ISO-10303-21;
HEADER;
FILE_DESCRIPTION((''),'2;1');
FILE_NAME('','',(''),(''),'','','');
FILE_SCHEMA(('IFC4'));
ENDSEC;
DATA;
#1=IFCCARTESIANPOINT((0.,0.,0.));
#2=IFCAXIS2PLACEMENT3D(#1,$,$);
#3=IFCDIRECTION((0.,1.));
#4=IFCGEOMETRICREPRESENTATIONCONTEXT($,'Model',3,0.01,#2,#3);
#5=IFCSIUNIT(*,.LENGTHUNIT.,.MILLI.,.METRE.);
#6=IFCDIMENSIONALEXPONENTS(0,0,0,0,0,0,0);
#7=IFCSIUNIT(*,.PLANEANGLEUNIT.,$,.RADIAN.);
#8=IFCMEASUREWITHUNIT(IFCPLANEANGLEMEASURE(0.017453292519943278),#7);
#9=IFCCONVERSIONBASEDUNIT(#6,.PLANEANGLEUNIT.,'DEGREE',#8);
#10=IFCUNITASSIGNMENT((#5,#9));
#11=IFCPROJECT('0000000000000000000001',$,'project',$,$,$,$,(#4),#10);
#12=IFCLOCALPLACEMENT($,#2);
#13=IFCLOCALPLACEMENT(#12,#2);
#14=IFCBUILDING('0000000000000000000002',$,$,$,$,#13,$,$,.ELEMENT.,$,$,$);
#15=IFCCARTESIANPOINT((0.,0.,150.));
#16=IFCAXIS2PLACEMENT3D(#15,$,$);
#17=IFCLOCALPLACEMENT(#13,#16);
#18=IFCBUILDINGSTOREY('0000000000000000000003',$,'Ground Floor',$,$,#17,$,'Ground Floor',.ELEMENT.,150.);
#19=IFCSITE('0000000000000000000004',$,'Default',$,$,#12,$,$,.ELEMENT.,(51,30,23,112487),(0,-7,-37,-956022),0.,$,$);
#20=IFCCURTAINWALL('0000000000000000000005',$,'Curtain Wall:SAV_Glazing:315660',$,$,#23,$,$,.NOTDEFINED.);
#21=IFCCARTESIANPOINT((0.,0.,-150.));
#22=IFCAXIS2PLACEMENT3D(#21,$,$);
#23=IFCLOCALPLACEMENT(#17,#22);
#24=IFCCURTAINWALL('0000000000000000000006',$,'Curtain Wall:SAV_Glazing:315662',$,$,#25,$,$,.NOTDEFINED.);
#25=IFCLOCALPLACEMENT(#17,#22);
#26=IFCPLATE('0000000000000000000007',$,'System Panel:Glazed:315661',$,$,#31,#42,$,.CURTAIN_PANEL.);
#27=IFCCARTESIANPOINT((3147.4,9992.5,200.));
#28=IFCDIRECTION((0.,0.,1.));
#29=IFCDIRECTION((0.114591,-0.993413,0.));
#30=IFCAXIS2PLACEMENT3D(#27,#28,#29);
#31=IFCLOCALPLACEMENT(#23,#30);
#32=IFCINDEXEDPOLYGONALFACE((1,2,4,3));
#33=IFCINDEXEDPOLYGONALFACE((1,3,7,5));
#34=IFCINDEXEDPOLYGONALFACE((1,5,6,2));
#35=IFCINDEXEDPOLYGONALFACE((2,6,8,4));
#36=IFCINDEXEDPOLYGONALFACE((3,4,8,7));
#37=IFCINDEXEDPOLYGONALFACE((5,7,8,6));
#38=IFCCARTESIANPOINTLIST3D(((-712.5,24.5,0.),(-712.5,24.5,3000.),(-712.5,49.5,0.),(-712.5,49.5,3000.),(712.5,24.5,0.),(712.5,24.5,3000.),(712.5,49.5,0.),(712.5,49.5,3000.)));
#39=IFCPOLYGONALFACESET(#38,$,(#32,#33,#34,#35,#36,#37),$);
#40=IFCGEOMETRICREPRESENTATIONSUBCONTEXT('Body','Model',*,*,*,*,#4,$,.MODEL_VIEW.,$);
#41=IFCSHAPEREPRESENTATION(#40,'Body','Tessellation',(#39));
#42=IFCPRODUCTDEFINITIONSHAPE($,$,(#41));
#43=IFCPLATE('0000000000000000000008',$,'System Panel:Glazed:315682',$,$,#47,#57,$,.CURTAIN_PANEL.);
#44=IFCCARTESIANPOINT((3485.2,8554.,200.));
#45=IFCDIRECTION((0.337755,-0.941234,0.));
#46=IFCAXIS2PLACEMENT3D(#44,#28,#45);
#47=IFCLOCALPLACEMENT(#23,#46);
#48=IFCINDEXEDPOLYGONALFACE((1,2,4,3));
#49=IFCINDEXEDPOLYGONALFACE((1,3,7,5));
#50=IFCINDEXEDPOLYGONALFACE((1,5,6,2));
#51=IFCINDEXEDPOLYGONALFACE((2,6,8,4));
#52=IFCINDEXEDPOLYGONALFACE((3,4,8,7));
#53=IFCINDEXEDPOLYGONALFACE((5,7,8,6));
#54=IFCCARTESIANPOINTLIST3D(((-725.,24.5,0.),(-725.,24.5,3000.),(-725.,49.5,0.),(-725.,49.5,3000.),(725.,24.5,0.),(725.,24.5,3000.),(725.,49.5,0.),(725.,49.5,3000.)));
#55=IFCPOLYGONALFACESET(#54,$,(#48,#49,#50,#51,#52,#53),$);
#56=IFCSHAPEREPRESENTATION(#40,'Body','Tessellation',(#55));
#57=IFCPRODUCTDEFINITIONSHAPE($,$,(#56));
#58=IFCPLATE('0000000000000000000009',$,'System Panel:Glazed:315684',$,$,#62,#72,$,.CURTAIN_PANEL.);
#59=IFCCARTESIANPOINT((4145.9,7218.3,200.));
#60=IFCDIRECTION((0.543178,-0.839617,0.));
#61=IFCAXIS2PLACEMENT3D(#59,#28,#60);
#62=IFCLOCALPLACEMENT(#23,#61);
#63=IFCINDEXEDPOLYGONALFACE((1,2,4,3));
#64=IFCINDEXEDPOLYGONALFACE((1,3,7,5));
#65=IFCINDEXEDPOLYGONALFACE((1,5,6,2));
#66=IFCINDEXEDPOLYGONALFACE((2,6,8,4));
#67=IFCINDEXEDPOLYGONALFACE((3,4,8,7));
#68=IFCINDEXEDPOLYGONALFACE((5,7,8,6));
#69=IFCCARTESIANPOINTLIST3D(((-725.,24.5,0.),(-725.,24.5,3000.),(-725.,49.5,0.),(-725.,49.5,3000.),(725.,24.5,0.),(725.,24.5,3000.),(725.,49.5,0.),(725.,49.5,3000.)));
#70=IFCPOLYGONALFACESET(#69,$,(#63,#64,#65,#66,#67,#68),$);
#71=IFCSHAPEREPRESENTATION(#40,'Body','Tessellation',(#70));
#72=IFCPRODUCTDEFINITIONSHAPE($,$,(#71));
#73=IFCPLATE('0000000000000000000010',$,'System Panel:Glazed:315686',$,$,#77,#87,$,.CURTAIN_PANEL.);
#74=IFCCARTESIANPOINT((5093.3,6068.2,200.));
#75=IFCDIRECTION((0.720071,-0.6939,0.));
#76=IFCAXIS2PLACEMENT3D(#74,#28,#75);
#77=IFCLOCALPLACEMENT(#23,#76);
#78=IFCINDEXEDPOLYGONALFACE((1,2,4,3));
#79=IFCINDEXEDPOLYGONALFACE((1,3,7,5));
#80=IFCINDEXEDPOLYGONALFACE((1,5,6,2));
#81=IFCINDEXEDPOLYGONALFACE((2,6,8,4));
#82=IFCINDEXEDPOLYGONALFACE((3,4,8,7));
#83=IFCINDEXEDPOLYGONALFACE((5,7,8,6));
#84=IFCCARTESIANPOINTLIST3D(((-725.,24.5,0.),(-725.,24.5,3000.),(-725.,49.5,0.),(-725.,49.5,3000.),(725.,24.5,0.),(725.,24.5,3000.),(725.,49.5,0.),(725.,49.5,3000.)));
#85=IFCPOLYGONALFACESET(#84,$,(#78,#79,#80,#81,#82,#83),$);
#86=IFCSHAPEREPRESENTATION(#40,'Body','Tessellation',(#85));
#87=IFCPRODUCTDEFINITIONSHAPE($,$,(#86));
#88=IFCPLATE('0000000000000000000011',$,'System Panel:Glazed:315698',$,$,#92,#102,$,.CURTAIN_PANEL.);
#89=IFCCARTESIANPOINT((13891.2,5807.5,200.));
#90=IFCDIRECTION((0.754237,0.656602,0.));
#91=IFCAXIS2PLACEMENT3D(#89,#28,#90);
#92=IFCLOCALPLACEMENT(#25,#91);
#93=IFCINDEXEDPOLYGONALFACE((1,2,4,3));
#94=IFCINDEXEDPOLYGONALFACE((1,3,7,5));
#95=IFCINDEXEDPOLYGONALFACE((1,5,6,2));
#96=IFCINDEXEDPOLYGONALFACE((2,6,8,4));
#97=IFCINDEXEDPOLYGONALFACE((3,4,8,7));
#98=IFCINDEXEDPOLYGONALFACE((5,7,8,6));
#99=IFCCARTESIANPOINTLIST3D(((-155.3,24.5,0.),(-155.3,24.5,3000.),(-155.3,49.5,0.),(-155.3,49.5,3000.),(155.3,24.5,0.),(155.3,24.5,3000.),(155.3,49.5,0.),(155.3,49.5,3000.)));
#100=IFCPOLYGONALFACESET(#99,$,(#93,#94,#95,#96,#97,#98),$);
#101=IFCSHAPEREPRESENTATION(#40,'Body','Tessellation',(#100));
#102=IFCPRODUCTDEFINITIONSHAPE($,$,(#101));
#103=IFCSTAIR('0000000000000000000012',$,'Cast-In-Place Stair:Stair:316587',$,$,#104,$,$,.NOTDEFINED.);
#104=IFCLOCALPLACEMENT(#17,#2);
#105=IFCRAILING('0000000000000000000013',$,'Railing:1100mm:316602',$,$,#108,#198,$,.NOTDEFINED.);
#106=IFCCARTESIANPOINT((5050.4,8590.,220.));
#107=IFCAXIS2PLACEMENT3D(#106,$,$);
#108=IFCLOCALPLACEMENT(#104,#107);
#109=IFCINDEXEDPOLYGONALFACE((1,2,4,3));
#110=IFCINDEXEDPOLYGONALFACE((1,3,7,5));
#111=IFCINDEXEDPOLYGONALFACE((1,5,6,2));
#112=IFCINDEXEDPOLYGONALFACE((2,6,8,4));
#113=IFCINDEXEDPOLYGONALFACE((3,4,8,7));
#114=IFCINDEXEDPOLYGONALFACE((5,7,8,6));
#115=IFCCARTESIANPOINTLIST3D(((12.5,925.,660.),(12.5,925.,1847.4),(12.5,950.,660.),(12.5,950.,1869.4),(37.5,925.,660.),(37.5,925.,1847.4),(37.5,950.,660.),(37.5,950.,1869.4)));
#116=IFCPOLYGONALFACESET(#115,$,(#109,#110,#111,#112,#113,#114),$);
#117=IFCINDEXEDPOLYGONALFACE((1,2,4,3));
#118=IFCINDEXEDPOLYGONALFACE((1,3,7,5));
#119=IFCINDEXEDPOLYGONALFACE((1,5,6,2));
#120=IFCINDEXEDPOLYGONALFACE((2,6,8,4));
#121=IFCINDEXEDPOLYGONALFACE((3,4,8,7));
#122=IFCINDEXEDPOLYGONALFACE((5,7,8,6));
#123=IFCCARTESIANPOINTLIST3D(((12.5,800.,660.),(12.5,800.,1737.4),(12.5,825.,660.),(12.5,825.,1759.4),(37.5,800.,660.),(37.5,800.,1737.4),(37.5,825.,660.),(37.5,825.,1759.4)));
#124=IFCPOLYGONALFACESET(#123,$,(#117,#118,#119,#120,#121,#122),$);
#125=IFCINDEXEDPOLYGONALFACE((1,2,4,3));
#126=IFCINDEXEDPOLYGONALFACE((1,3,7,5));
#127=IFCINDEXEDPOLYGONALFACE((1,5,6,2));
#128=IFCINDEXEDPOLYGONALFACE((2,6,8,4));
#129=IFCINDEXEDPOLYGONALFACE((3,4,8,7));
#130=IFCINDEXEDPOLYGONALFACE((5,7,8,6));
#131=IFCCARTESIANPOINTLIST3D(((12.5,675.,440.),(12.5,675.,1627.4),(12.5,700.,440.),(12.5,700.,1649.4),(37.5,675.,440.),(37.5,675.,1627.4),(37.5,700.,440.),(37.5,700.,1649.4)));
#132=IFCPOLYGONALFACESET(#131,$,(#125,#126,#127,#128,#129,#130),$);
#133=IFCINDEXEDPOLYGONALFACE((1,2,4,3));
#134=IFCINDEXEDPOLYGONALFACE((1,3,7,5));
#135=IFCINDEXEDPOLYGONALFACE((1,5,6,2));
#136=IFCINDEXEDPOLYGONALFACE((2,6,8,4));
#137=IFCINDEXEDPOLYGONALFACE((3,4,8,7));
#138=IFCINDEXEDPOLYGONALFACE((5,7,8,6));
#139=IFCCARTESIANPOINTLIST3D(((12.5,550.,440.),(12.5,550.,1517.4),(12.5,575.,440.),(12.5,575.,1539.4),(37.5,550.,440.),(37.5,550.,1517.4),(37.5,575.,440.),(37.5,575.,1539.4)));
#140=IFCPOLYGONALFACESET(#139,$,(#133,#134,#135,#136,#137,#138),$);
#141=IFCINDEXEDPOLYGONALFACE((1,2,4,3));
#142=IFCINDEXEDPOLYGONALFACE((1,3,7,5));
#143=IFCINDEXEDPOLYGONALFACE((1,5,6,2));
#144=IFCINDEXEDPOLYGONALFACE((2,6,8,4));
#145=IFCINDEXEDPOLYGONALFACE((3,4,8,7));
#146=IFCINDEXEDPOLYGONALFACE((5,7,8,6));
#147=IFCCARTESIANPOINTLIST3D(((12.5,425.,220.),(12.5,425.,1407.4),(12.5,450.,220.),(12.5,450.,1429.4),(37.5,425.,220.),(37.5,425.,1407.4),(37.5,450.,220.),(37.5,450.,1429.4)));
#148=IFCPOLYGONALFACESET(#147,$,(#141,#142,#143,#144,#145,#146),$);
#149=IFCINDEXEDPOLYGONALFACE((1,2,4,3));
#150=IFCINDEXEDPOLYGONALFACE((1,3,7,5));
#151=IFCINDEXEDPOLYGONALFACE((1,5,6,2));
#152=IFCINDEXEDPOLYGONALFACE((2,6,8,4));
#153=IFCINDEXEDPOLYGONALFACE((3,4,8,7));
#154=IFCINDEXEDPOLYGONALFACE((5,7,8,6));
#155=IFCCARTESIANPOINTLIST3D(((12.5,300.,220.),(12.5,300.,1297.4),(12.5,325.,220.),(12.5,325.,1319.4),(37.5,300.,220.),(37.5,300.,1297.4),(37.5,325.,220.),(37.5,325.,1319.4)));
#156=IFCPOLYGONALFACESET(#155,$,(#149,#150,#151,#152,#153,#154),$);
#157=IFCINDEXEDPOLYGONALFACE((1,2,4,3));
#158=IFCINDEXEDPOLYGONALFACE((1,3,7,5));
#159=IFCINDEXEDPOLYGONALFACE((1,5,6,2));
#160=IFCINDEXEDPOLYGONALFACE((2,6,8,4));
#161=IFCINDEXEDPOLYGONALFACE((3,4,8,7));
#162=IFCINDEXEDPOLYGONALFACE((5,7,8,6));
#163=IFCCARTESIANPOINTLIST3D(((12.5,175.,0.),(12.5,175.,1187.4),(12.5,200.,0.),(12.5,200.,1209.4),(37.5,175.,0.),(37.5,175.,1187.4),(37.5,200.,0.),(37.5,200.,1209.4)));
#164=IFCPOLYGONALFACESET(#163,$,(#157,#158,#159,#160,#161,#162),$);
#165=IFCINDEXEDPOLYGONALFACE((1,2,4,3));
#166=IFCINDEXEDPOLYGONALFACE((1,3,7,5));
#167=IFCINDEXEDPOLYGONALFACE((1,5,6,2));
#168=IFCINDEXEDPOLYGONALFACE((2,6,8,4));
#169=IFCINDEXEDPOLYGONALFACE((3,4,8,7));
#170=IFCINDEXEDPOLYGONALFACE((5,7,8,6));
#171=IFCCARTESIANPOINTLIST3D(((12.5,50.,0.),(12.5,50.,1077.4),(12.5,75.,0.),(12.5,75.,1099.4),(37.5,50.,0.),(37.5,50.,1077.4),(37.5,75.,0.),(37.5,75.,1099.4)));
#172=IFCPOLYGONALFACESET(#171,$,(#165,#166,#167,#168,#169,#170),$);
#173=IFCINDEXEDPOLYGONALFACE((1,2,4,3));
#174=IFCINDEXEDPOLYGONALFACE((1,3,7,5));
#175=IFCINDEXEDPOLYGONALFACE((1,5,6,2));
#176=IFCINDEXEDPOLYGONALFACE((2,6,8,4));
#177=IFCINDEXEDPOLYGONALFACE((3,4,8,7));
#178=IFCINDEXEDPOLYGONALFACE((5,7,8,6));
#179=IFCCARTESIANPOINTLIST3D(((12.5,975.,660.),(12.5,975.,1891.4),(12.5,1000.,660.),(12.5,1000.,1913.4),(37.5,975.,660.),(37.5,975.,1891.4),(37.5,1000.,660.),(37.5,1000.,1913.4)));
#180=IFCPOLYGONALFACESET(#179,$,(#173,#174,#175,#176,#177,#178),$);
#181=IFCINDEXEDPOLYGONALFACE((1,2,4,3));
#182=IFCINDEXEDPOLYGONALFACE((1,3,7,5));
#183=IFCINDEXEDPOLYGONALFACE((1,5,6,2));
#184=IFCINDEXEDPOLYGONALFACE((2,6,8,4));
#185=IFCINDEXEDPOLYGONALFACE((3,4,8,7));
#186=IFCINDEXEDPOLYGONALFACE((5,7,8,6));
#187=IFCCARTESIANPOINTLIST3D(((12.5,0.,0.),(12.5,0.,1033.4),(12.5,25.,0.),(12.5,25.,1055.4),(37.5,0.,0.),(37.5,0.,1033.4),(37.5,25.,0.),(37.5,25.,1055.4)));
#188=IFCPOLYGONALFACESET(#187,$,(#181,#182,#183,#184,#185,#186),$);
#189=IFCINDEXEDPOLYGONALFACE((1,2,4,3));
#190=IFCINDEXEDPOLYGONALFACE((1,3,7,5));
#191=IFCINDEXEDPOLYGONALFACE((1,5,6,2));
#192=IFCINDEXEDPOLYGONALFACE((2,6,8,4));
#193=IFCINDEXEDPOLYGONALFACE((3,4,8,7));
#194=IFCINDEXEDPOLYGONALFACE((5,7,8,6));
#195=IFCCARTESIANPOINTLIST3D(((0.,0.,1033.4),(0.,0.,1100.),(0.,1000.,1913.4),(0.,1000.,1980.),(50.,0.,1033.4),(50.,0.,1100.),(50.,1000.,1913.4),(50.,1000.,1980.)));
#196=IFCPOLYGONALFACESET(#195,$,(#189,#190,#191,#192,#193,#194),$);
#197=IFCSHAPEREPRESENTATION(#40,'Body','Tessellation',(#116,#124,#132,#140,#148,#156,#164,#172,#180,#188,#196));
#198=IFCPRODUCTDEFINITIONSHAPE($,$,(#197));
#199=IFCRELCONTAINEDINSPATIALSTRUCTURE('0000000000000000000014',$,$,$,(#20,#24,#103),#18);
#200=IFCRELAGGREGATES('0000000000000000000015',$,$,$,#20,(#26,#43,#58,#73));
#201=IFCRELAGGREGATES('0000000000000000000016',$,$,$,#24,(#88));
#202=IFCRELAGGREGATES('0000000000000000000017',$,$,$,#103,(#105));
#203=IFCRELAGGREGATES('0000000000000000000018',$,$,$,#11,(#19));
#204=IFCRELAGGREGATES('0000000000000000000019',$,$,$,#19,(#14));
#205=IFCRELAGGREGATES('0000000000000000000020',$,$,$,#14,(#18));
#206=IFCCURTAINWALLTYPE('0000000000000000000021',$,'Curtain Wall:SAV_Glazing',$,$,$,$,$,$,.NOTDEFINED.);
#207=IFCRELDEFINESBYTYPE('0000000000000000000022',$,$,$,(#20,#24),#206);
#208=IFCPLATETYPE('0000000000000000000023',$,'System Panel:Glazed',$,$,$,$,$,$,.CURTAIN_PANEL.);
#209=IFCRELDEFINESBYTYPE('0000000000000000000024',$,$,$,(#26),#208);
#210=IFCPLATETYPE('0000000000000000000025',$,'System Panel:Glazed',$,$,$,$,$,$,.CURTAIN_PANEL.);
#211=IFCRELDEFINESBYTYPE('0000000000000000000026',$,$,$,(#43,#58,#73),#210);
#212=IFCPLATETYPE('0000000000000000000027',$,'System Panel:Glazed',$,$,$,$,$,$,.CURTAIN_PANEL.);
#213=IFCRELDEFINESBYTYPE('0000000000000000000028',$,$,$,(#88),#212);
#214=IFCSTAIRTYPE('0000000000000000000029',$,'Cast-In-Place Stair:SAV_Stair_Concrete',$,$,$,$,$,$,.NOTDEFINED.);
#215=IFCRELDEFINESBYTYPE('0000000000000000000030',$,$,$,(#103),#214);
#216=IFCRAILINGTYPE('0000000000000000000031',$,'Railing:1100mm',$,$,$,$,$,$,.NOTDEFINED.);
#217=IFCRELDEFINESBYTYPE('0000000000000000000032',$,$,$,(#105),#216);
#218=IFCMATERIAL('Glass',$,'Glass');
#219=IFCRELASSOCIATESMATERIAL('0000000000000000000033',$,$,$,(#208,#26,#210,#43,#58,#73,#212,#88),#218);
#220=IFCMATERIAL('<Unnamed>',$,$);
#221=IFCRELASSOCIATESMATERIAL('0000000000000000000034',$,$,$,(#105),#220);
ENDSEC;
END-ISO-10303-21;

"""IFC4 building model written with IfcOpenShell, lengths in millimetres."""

from ifc_helpers import new_model, entity, si_unit, converted_unit, direction, frame, frame_2d, origin, place, context, subcontext, project, spatial, polyline, rectangle, outline, extrude, source, transform, mapped, material, type_object, type_shapes, element, aggregate, save


model = new_model("IFC4")

# Units and contexts
model_context = context("Model", 3, precision=0.01, world=origin(), true_north=direction((0.0, 1.0)))
body_context = subcontext(model_context, "Body", "Model", "MODEL_VIEW")
ifc_project = project(units=[si_unit("LENGTHUNIT", "METRE", prefix="MILLI"), converted_unit("PLANEANGLEUNIT", "DEGREE", entity("IfcPlaneAngleMeasure", 0.017453292519943278), si_unit("PLANEANGLEUNIT", "RADIAN"), dimensions=[0, 0, 0, 0, 0, 0, 0])], contexts=[model_context])

# Site, building, storey
site_placement = place(None, origin())
site = spatial("IfcSite", under=ifc_project, at=site_placement, Name="Default", CompositionType="ELEMENT", RefLatitude=(51, 30, 23, 112487), RefLongitude=(0, -7, -37, -956022), RefElevation=0.0)
building_placement = place(site_placement, origin())
building = spatial("IfcBuilding", under=site, at=building_placement, CompositionType="ELEMENT")
storey_placement = place(building_placement, frame((0.0, 0.0, 150.0)))
storey = spatial("IfcBuildingStorey", under=building, at=storey_placement, Name="Ground Floor", LongName="Ground Floor", CompositionType="ELEMENT", Elevation=150.0)

# Curtain walls
curtain_wall_type = type_object("IfcCurtainWallType", Name="Curtain Wall:SAV_Glazing", PredefinedType="NOTDEFINED")
curtain_wall_1_placement = place(storey_placement, frame((0.0, 0.0, -150.0)))
curtain_wall_1 = element("IfcCurtainWall", 1, at=curtain_wall_1_placement, inside=storey, type_object=curtain_wall_type, Name="Curtain Wall:SAV_Glazing:315660", PredefinedType="NOTDEFINED")
curtain_wall_2_placement = place(storey_placement, frame((0.0, 0.0, -150.0)))
curtain_wall_2 = element("IfcCurtainWall", 2, at=curtain_wall_2_placement, inside=storey, type_object=curtain_wall_type, Name="Curtain Wall:SAV_Glazing:315662", PredefinedType="NOTDEFINED")

# Plates
ifc_material_1 = material(Name="Glass", Category="Glass")
plate_type_1 = type_object("IfcPlateType", Name="System Panel:Glazed", PredefinedType="CURTAIN_PANEL", material=ifc_material_1)
shared_shape_1 = source(origin(), body_context, "Body", "SweptSolid", [
    extrude(rectangle(XDim=25.0, YDim=1425.0, at=frame_2d((0.0, 0.0), x_axis=(1.0, 0.0))), frame((0.0, 37.0, 0.0), z_axis=(0.0, 0.0, 1.0), x_axis=(0.0, 1.0, 0.0)), (0.0, 0.0, 1.0), 3000.0),
])
type_shapes(plate_type_1, [shared_shape_1])
plate_1_placement = place(curtain_wall_1_placement, frame((3147.4, 9992.5, 200.0), z_axis=(0.0, 0.0, 1.0), x_axis=(0.114591, -0.993413, 0.0)))
plate_1 = element("IfcPlate", 3, at=plate_1_placement, type_object=plate_type_1, material=ifc_material_1, Name="System Panel:Glazed:315661", PredefinedType="CURTAIN_PANEL", context=body_context, shape_type="MappedRepresentation", body=[
    mapped(shared_shape_1, transform((0.0, 0.0, 0.0), scale=1.0)),
])
plate_type_2 = type_object("IfcPlateType", Name="System Panel:Glazed", PredefinedType="CURTAIN_PANEL", material=ifc_material_1)
shared_shape_2 = source(origin(), body_context, "Body", "SweptSolid", [
    extrude(rectangle(XDim=25.0, YDim=1450.0, at=frame_2d((0.0, 0.0), x_axis=(1.0, 0.0))), frame((0.0, 37.0, 0.0), z_axis=(0.0, 0.0, 1.0), x_axis=(0.0, 1.0, 0.0)), (0.0, 0.0, 1.0), 3000.0),
])
type_shapes(plate_type_2, [shared_shape_2])
plate_2_placement = place(curtain_wall_1_placement, frame((3485.2, 8554.0, 200.0), z_axis=(0.0, 0.0, 1.0), x_axis=(0.337755, -0.941234, 0.0)))
plate_2 = element("IfcPlate", 4, at=plate_2_placement, type_object=plate_type_2, material=ifc_material_1, Name="System Panel:Glazed:315682", PredefinedType="CURTAIN_PANEL", context=body_context, shape_type="MappedRepresentation", body=[
    mapped(shared_shape_2, transform((0.0, 0.0, 0.0), scale=1.0)),
])
plate_3_placement = place(curtain_wall_1_placement, frame((4145.9, 7218.3, 200.0), z_axis=(0.0, 0.0, 1.0), x_axis=(0.543178, -0.839617, 0.0)))
plate_3 = element("IfcPlate", 5, at=plate_3_placement, type_object=plate_type_2, material=ifc_material_1, Name="System Panel:Glazed:315684", PredefinedType="CURTAIN_PANEL", context=body_context, shape_type="MappedRepresentation", body=[
    mapped(shared_shape_2, transform((0.0, 0.0, 0.0), scale=1.0)),
])
plate_4_placement = place(curtain_wall_1_placement, frame((5093.3, 6068.2, 200.0), z_axis=(0.0, 0.0, 1.0), x_axis=(0.720071, -0.6939, 0.0)))
plate_4 = element("IfcPlate", 6, at=plate_4_placement, type_object=plate_type_2, material=ifc_material_1, Name="System Panel:Glazed:315686", PredefinedType="CURTAIN_PANEL", context=body_context, shape_type="MappedRepresentation", body=[
    mapped(shared_shape_2, transform((0.0, 0.0, 0.0), scale=1.0)),
])
aggregate(curtain_wall_1, [plate_1, plate_2, plate_3, plate_4])
plate_type_3 = type_object("IfcPlateType", Name="System Panel:Glazed", PredefinedType="CURTAIN_PANEL", material=ifc_material_1)
shared_shape_3 = source(origin(), body_context, "Body", "SweptSolid", [
    extrude(rectangle(XDim=25.0, YDim=310.6, at=frame_2d((0.0, 0.0), x_axis=(1.0, 0.0))), frame((0.0, 37.0, 0.0), z_axis=(0.0, 0.0, 1.0), x_axis=(0.0, 1.0, 0.0)), (0.0, 0.0, 1.0), 3000.0),
])
type_shapes(plate_type_3, [shared_shape_3])
plate_5_placement = place(curtain_wall_2_placement, frame((13891.2, 5807.5, 200.0), z_axis=(0.0, 0.0, 1.0), x_axis=(0.754237, 0.656602, 0.0)))
plate_5 = element("IfcPlate", 7, at=plate_5_placement, type_object=plate_type_3, material=ifc_material_1, Name="System Panel:Glazed:315698", PredefinedType="CURTAIN_PANEL", context=body_context, shape_type="MappedRepresentation", body=[
    mapped(shared_shape_3, transform((0.0, 0.0, 0.0), scale=1.0)),
])
aggregate(curtain_wall_2, [plate_5])

# Shared definitions
ifc_material_2 = material(Name="<Unnamed>")

# Stair, railing
stair_type = type_object("IfcStairType", Name="Cast-In-Place Stair:SAV_Stair_Concrete", PredefinedType="NOTDEFINED")
stair_placement = place(storey_placement, origin())
stair = element("IfcStair", 8, at=stair_placement, inside=storey, type_object=stair_type, Name="Cast-In-Place Stair:Stair:316587", PredefinedType="NOTDEFINED")
railing_type_1 = type_object("IfcRailingType", Name="Railing:1100mm", PredefinedType="NOTDEFINED")
railing_1_placement = place(stair_placement, frame((5050.4, 8590.0, 220.0)))
railing_1 = element("IfcRailing", 9, at=railing_1_placement, type_object=railing_type_1, material=ifc_material_2, Name="Railing:1100mm:316602", PredefinedType="NOTDEFINED", context=body_context, shape_type="SweptSolid", body=[
    extrude(outline(polyline([(-588.2, -12.5), (599.2, -12.5), (599.2, 12.5), (-610.2, 12.5), (-588.2, -12.5)])), frame((12.5, 937.5, 1259.2), z_axis=(1.0, 0.0, 0.0), x_axis=(0.0, 0.0, -1.0)), (0.0, 0.0, 1.0), 25.0),
    extrude(outline(polyline([(-533.2, -12.5), (544.2, -12.5), (544.2, 12.5), (-555.2, 12.5), (-533.2, -12.5)])), frame((12.5, 812.5, 1204.2), z_axis=(1.0, 0.0, 0.0), x_axis=(0.0, 0.0, -1.0)), (0.0, 0.0, 1.0), 25.0),
    extrude(outline(polyline([(-588.2, -12.5), (599.2, -12.5), (599.2, 12.5), (-610.2, 12.5), (-588.2, -12.5)])), frame((12.5, 687.5, 1039.2), z_axis=(1.0, 0.0, 0.0), x_axis=(0.0, 0.0, -1.0)), (0.0, 0.0, 1.0), 25.0),
    extrude(outline(polyline([(-533.2, -12.5), (544.2, -12.5), (544.2, 12.5), (-555.2, 12.5), (-533.2, -12.5)])), frame((12.5, 562.5, 984.2), z_axis=(1.0, 0.0, 0.0), x_axis=(0.0, 0.0, -1.0)), (0.0, 0.0, 1.0), 25.0),
    extrude(outline(polyline([(-588.2, -12.5), (599.2, -12.5), (599.2, 12.5), (-610.2, 12.5), (-588.2, -12.5)])), frame((12.5, 437.5, 819.2), z_axis=(1.0, 0.0, 0.0), x_axis=(0.0, 0.0, -1.0)), (0.0, 0.0, 1.0), 25.0),
    extrude(outline(polyline([(-533.2, -12.5), (544.2, -12.5), (544.2, 12.5), (-555.2, 12.5), (-533.2, -12.5)])), frame((12.5, 312.5, 764.2), z_axis=(1.0, 0.0, 0.0), x_axis=(0.0, 0.0, -1.0)), (0.0, 0.0, 1.0), 25.0),
    extrude(outline(polyline([(-588.2, -12.5), (599.2, -12.5), (599.2, 12.5), (-610.2, 12.5), (-588.2, -12.5)])), frame((12.5, 187.5, 599.2), z_axis=(1.0, 0.0, 0.0), x_axis=(0.0, 0.0, -1.0)), (0.0, 0.0, 1.0), 25.0),
    extrude(outline(polyline([(-533.2, -12.5), (544.2, -12.5), (544.2, 12.5), (-555.2, 12.5), (-533.2, -12.5)])), frame((12.5, 62.5, 544.2), z_axis=(1.0, 0.0, 0.0), x_axis=(0.0, 0.0, -1.0)), (0.0, 0.0, 1.0), 25.0),
    extrude(outline(polyline([(-610.2, -12.5), (621.2, -12.5), (621.2, 12.5), (-632.2, 12.5), (-610.2, -12.5)])), frame((12.5, 987.5, 1281.2), z_axis=(1.0, 0.0, 0.0), x_axis=(0.0, 0.0, -1.0)), (0.0, 0.0, 1.0), 25.0),
    extrude(outline(polyline([(-511.2, -12.5), (522.2, -12.5), (522.2, 12.5), (-533.2, 12.5), (-511.2, -12.5)])), frame((12.5, 12.5, 522.2), z_axis=(1.0, 0.0, 0.0), x_axis=(0.0, 0.0, -1.0)), (0.0, 0.0, 1.0), 25.0),
    extrude(outline(polyline([(-688.0, -25.0), (644.0, -25.0), (688.0, 25.0), (-644.0, 25.0), (-688.0, -25.0)])), frame((0.0, 500.0, 1506.7), z_axis=(1.0, 0.0, 0.0), x_axis=(0.0, 0.750714, 0.660628)), (0.0, 0.0, 1.0), 50.0),
])
aggregate(stair, [railing_1])

save(model, "model.ifc")
